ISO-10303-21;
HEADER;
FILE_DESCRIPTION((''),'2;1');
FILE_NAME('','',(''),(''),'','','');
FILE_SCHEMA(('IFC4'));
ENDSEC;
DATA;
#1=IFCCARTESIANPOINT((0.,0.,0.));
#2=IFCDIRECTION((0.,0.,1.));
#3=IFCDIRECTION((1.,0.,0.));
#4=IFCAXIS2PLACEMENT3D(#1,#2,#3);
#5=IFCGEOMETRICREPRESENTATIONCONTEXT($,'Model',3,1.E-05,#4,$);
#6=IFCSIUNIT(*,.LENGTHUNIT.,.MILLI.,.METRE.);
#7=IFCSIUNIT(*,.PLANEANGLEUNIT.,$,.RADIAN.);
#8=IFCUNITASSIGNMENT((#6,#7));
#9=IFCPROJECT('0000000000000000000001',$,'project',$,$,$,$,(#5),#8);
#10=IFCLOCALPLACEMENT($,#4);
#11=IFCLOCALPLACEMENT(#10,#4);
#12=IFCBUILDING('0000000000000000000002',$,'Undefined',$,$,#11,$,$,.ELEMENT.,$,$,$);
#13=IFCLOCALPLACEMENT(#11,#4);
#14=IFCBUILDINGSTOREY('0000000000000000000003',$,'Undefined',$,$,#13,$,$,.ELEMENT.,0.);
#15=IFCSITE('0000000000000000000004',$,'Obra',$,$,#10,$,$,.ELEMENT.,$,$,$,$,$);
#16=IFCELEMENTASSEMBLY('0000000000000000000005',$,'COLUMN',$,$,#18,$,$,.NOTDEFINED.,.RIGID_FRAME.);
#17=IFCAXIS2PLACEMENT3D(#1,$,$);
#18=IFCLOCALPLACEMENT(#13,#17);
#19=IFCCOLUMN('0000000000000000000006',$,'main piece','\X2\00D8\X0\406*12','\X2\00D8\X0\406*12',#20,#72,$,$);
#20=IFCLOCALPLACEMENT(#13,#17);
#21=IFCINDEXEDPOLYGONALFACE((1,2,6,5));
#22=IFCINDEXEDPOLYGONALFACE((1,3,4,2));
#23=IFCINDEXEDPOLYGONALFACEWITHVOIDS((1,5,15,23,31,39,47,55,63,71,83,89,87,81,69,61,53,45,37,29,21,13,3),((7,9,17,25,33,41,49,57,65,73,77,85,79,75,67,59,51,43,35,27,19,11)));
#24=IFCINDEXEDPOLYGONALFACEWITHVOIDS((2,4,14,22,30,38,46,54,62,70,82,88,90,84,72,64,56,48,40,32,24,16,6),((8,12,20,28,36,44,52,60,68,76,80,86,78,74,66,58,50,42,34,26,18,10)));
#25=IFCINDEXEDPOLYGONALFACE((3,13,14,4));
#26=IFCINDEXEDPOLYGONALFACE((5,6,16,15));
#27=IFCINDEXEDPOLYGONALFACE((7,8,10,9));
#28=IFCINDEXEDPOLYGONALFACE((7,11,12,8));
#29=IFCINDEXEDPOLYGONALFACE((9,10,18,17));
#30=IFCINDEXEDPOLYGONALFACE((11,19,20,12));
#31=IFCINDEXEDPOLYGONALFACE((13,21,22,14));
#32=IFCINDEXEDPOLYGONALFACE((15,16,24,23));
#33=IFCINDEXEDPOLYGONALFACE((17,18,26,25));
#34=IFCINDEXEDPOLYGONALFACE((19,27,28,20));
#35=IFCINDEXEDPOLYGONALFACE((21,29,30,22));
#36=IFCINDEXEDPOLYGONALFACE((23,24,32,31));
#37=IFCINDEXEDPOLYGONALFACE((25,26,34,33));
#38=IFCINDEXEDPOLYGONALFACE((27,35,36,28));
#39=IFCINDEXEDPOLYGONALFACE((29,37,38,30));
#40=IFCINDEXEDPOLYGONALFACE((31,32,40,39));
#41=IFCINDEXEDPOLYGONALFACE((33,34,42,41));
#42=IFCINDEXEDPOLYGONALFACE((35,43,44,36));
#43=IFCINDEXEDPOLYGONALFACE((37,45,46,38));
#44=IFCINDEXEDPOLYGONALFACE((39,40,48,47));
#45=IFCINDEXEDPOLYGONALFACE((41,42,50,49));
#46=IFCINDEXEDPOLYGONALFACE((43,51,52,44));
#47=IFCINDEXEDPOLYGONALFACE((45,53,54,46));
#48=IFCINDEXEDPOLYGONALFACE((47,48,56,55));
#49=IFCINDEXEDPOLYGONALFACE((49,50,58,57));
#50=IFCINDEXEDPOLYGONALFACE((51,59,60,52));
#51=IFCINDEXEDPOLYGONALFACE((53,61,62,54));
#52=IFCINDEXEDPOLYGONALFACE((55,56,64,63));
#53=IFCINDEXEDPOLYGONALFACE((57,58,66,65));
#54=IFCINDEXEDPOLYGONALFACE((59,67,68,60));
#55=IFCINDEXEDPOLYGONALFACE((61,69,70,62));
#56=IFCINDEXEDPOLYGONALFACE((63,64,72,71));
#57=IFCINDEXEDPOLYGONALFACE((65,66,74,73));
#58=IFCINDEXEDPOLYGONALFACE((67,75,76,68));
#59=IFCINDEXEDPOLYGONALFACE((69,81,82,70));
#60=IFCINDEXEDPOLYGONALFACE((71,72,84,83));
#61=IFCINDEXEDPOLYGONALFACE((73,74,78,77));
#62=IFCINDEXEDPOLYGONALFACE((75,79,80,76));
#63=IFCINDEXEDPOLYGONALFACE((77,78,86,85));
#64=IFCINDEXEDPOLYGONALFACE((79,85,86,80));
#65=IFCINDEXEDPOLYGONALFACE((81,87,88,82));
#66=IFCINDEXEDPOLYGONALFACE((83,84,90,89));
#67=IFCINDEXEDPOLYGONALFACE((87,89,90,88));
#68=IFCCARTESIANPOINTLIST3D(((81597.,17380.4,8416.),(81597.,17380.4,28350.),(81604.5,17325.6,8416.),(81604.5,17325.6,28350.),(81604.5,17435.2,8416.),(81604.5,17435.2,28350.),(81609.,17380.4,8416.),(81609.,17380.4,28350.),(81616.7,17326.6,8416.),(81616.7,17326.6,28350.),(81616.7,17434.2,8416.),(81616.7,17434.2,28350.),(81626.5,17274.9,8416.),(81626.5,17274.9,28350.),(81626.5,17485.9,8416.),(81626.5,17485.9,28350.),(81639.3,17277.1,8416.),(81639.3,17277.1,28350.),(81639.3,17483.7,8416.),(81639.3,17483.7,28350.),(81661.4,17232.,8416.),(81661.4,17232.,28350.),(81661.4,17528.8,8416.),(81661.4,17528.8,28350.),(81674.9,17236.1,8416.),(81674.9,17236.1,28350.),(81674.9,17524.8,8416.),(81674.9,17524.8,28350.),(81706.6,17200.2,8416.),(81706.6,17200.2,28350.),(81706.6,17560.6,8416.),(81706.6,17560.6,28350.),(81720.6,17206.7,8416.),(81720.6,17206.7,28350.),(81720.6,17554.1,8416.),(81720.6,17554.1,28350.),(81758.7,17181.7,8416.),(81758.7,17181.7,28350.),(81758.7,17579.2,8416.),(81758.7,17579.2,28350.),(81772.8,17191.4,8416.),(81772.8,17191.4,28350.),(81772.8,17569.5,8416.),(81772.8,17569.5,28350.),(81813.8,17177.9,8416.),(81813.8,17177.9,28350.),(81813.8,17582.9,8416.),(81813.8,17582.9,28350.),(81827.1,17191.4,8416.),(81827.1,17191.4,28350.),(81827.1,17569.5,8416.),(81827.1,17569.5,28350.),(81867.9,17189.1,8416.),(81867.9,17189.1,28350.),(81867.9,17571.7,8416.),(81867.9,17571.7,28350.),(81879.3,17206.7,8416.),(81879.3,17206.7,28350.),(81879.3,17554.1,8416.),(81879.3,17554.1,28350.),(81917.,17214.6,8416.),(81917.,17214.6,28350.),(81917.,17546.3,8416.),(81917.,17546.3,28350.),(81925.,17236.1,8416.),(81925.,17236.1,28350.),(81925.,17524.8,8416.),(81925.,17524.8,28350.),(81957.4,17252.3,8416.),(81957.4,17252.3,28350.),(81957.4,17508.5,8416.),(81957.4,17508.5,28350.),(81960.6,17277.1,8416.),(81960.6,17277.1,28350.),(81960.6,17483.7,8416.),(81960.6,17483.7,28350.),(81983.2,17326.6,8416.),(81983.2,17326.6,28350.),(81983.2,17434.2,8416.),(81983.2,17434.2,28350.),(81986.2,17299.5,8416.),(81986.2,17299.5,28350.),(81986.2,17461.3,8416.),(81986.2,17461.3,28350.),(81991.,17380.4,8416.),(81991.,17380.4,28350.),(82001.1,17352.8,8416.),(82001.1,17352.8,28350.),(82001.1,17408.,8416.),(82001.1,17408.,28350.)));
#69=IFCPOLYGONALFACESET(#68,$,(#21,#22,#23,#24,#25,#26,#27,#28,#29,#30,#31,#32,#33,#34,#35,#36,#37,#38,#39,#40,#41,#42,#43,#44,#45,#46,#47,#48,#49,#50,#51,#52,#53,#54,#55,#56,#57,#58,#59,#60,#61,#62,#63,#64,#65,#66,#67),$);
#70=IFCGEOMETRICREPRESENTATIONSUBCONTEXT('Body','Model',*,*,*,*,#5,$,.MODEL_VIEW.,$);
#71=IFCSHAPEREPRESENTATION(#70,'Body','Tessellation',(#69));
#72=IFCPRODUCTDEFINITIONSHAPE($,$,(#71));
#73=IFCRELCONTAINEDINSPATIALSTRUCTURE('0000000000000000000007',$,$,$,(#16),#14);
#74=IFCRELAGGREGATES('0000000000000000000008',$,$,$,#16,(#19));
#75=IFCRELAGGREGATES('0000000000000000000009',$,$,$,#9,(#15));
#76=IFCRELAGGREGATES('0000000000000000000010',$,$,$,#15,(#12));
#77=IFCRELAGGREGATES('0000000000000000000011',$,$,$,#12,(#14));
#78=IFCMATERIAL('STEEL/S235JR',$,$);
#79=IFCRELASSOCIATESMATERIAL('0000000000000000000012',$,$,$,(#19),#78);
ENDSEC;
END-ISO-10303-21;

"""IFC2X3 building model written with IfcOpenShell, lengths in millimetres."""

from ifc_helpers import new_model, si_unit, frame, origin_with_axes, origin_2d_with_axis, place, context, subcontext, project, spatial, hollow_circle, extrude, clip, halfspace, material, element, aggregate, save


model = new_model("IFC2X3")

# Units and contexts
model_context = context("Model", 3, precision=1e-05, world=origin_with_axes())
body_context = subcontext(model_context, "Body", "Model", "MODEL_VIEW")
ifc_project = project(units=[si_unit("LENGTHUNIT", "METRE", prefix="MILLI"), si_unit("PLANEANGLEUNIT", "RADIAN")], contexts=[model_context])

# Site, building, storey
site_placement = place(None, origin_with_axes())
site = spatial("IfcSite", under=ifc_project, at=site_placement, Name="Obra", CompositionType="ELEMENT")
building_placement = place(site_placement, origin_with_axes())
building = spatial("IfcBuilding", under=site, at=building_placement, Name="Undefined", CompositionType="ELEMENT")
storey_placement = place(building_placement, origin_with_axes())
storey = spatial("IfcBuildingStorey", under=building, at=storey_placement, Name="Undefined", CompositionType="ELEMENT", Elevation=0.0)

# Element assembly, column
assembly_1_placement = place(storey_placement, origin_with_axes())
assembly_1 = element("IfcElementAssembly", 1, at=assembly_1_placement, inside=storey, Name="COLUMN", AssemblyPlace="NOTDEFINED", PredefinedType="RIGID_FRAME")
ifc_material_1 = material(Name="STEEL/S235JR")
column_placement = place(assembly_1_placement, frame((81800.0, 17380.4, 8400.0), z_axis=(0.0, 0.0, 1.0), x_axis=(0.0, 1.0, 0.0)))
column = element("IfcColumn", 2, at=column_placement, material=ifc_material_1, Name="main piece", Description="Ø406*12", ObjectType="Ø406*12", context=body_context, shape_type="Clipping", body=[
    clip(extrude(hollow_circle(Radius=203.0, WallThickness=12.0, at=origin_2d_with_axis()), frame((0.0, 0.0, 19950.0), z_axis=(0.0, 0.0, -1.0), x_axis=(0.0, 1.0, 0.0)), (0.0, 0.0, 1.0), 19934.0), halfspace(frame((-203.0, 0.0, 16.0), z_axis=(0.0, 0.0, 1.0), x_axis=(0.0, 1.0, 0.0)), True)),
])

aggregate(assembly_1, [column])

save(model, "model.ifc")
